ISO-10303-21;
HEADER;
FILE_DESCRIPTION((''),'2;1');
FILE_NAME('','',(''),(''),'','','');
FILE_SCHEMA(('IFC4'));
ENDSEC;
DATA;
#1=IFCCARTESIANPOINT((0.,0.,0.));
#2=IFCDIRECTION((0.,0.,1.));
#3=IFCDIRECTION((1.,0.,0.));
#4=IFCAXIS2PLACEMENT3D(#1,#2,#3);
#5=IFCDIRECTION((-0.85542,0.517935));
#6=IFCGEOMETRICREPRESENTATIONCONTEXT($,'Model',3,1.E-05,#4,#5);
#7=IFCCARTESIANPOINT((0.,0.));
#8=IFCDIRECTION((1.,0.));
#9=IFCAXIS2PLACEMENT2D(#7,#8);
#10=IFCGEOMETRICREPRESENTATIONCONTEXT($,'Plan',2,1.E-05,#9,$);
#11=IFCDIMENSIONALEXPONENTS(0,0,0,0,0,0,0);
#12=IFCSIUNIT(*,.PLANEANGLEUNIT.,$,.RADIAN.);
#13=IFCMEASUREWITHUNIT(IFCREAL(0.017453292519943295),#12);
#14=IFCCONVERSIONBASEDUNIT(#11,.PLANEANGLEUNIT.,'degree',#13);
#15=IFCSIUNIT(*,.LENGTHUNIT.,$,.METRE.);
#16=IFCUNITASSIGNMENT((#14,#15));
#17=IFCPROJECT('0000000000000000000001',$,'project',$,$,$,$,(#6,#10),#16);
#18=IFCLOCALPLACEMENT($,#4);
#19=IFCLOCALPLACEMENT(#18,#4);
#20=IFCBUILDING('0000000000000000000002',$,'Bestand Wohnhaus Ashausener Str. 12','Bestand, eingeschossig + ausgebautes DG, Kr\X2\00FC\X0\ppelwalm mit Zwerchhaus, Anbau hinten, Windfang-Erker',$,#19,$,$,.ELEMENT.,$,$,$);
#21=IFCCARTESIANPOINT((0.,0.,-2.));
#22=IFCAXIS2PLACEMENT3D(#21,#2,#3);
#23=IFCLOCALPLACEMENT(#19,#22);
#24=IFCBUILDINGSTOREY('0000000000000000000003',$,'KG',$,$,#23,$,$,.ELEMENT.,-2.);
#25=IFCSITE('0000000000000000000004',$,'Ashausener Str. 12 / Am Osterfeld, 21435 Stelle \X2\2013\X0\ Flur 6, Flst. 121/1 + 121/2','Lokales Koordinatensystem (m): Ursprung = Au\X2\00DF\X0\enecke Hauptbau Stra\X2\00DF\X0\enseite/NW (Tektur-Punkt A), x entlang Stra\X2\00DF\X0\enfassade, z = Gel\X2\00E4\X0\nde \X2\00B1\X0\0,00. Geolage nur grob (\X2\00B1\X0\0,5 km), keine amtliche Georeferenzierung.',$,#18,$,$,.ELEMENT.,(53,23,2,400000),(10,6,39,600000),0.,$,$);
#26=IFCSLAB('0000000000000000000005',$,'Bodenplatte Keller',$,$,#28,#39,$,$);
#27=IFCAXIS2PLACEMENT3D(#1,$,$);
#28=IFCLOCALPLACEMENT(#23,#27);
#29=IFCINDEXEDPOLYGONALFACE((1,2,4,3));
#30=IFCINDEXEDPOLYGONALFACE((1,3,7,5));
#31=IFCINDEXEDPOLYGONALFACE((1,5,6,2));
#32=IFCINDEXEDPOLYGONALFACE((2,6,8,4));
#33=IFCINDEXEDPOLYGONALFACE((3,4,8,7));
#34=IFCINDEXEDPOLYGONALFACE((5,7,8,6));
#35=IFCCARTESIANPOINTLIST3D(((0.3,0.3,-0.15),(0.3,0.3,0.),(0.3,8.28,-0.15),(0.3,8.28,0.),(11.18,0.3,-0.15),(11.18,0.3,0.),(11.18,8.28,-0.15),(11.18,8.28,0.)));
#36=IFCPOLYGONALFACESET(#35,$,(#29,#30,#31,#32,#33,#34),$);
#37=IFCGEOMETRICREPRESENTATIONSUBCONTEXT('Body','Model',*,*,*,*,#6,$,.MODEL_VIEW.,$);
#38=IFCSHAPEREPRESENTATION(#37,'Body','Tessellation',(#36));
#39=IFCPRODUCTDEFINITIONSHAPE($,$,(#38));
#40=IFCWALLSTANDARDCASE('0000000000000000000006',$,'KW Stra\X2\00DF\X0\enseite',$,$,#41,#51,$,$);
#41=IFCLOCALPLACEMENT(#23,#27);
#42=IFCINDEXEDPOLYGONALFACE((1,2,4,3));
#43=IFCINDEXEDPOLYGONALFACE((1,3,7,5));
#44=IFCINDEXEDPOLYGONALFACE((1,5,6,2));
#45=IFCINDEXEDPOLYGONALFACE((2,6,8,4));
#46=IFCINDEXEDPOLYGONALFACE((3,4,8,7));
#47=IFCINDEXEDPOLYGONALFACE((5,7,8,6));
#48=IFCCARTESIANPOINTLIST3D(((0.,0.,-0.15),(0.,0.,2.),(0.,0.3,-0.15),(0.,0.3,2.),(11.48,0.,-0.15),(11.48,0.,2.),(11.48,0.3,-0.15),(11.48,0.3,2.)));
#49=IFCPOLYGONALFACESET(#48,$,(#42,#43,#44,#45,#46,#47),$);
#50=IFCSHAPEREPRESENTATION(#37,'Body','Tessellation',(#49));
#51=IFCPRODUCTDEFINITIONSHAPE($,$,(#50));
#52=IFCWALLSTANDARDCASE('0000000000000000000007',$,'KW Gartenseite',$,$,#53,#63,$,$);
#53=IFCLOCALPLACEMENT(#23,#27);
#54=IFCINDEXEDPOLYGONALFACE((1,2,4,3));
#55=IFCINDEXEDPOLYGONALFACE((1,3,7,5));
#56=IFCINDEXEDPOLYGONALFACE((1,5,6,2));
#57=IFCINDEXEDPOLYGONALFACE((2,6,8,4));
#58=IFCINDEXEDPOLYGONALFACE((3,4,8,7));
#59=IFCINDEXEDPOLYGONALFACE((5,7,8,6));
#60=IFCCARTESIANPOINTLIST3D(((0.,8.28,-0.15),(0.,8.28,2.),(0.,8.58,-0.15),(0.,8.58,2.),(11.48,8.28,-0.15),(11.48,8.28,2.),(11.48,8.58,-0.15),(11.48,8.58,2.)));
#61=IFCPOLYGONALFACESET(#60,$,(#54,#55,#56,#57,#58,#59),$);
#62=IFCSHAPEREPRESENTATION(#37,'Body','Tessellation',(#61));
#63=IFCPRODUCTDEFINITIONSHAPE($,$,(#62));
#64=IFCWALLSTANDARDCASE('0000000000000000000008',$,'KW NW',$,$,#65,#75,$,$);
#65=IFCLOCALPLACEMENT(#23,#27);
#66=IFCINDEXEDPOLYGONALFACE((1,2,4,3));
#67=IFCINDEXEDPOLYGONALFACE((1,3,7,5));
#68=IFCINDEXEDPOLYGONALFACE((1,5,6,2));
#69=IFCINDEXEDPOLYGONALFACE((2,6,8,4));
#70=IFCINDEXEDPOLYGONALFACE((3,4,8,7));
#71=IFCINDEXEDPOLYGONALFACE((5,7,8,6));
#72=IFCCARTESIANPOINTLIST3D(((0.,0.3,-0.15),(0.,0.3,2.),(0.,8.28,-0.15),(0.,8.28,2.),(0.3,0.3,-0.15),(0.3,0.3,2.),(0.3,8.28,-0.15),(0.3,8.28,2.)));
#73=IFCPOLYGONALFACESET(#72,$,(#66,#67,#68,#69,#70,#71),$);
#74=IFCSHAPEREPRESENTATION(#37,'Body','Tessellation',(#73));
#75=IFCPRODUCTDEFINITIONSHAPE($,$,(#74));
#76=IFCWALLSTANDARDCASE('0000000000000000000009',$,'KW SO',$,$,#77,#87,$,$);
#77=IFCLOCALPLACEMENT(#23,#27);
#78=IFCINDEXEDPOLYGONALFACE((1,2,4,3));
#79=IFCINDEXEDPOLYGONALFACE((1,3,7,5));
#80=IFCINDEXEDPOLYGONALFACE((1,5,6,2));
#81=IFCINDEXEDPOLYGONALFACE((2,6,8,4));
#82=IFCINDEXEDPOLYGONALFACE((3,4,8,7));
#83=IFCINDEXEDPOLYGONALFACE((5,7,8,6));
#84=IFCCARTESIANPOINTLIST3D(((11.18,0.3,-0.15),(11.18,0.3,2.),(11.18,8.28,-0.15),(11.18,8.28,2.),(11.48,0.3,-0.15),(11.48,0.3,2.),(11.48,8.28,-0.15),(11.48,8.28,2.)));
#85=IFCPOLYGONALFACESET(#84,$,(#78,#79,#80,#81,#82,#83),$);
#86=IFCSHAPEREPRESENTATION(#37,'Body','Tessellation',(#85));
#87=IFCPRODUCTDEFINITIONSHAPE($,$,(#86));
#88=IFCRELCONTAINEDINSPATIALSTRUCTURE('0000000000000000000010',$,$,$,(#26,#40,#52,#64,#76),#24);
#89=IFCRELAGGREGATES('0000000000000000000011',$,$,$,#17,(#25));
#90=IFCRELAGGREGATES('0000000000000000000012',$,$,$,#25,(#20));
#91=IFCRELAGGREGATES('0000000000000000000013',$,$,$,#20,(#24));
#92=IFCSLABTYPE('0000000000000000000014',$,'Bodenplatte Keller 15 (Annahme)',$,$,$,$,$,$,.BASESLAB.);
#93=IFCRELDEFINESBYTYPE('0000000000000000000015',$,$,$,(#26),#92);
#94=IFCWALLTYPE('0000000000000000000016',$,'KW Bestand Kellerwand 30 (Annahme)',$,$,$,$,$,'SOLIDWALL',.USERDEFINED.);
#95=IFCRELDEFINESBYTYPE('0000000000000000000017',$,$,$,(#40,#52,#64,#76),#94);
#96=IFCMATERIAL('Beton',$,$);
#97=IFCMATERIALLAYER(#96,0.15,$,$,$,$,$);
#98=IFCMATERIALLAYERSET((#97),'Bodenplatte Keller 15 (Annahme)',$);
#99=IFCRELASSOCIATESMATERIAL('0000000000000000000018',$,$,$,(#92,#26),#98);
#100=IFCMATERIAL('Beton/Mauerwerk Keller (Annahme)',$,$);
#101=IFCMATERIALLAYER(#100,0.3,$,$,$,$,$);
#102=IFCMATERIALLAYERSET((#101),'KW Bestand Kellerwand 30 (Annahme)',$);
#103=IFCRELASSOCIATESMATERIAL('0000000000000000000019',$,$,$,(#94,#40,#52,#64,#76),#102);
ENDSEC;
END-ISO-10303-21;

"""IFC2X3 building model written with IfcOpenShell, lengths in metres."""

from ifc_helpers import new_model, entity, si_unit, converted_unit, direction, frame, origin_with_axes, origin_2d_with_axis, place, context, subcontext, project, spatial, polyline, outline, extrude, material, layer, layer_set, layer_usage, type_object, element, save


model = new_model("IFC2X3")

# Units and contexts
model_context = context("Model", 3, precision=1e-05, world=origin_with_axes(), true_north=direction((-0.85542, 0.517935)))
plan_context = context("Plan", 2, precision=1e-05, world=origin_2d_with_axis())
body_context = subcontext(model_context, "Body", "Model", "MODEL_VIEW")
ifc_project = project(units=[converted_unit("PLANEANGLEUNIT", "degree", entity("IfcReal", 0.017453292519943295), si_unit("PLANEANGLEUNIT", "RADIAN"), dimensions=[0, 0, 0, 0, 0, 0, 0]), si_unit("LENGTHUNIT", "METRE")], contexts=[model_context, plan_context])

# Site, building, storey
site_placement = place(None, origin_with_axes())
site = spatial("IfcSite", under=ifc_project, at=site_placement, Name="Ashausener Str. 12 / Am Osterfeld, 21435 Stelle – Flur 6, Flst. 121/1 + 121/2", Description="Lokales Koordinatensystem (m): Ursprung = Außenecke Hauptbau Straßenseite/NW (Tektur-Punkt A), x entlang Straßenfassade, z = Gelände ±0,00. Geolage nur grob (±0,5 km), keine amtliche Georeferenzierung.", CompositionType="ELEMENT", RefLatitude=(53, 23, 2, 400000), RefLongitude=(10, 6, 39, 600000), RefElevation=0.0)
building_placement = place(site_placement, origin_with_axes())
building = spatial("IfcBuilding", under=site, at=building_placement, Name="Bestand Wohnhaus Ashausener Str. 12", Description="Bestand, eingeschossig + ausgebautes DG, Krüppelwalm mit Zwerchhaus, Anbau hinten, Windfang-Erker", CompositionType="ELEMENT")
storey_placement = place(building_placement, frame((0.0, 0.0, -2.0), z_axis=(0.0, 0.0, 1.0), x_axis=(1.0, 0.0, 0.0)))
storey = spatial("IfcBuildingStorey", under=building, at=storey_placement, Name="KG", CompositionType="ELEMENT", Elevation=-2.0)

# Slab
ifc_material_1 = material(Name="Beton")
ifc_layer_1 = layer(ifc_material_1, 0.15)
ifc_layer_set_1 = layer_set([ifc_layer_1], Name="Bodenplatte Keller 15 (Annahme)")
ifc_layer_usage_1 = layer_usage(ifc_layer_set_1, "AXIS3", "POSITIVE", 0.0)
slab_type = type_object("IfcSlabType", Name="Bodenplatte Keller 15 (Annahme)", PredefinedType="BASESLAB", material=ifc_layer_set_1)
slab_placement = place(storey_placement, frame((0.0, 0.0, 2.0), z_axis=(0.0, 0.0, 1.0), x_axis=(1.0, 0.0, 0.0)))
element("IfcSlab", 1, at=slab_placement, inside=storey, type_object=slab_type, material=ifc_layer_usage_1, Name="Bodenplatte Keller", context=body_context, shape_type="SweptSolid", body=[
    extrude(outline(polyline([(0.3, 0.3), (11.18, 0.3), (11.18, 8.28), (0.3, 8.28), (0.3, 0.3)])), frame((0.0, 0.0, -2.15)), (0.0, 0.0, 1.0), 0.15),
])

# Walls
ifc_material_2 = material(Name="Beton/Mauerwerk Keller (Annahme)")
ifc_layer_2 = layer(ifc_material_2, 0.3)
ifc_layer_set_2 = layer_set([ifc_layer_2], Name="KW Bestand Kellerwand 30 (Annahme)")
ifc_layer_usage_2 = layer_usage(ifc_layer_set_2, "AXIS2", "POSITIVE", 0.0)
wall_type = type_object("IfcWallType", Name="KW Bestand Kellerwand 30 (Annahme)", ElementType="SOLIDWALL", PredefinedType="USERDEFINED", material=ifc_layer_set_2)
wall_1_placement = place(storey_placement, frame((0.0, 0.0, -0.15), z_axis=(0.0, 0.0, 1.0), x_axis=(1.0, 0.0, 0.0)))
element("IfcWallStandardCase", 2, at=wall_1_placement, inside=storey, type_object=wall_type, material=ifc_layer_usage_2, Name="KW Straßenseite", context=body_context, shape_type="SweptSolid", body=[
    extrude(outline(polyline([(0.0, 0.0), (0.0, 0.3), (11.48, 0.3), (11.48, 0.0), (0.0, 0.0)])), origin_with_axes(), (0.0, 0.0, 1.0), 2.15),
])
ifc_layer_usage_3 = layer_usage(ifc_layer_set_2, "AXIS2", "POSITIVE", 0.0)
wall_2_placement = place(storey_placement, frame((11.48, 8.58, -0.15), z_axis=(0.0, 0.0, 1.0), x_axis=(-1.0, 0.0, 0.0)))
element("IfcWallStandardCase", 3, at=wall_2_placement, inside=storey, type_object=wall_type, material=ifc_layer_usage_3, Name="KW Gartenseite", context=body_context, shape_type="SweptSolid", body=[
    extrude(outline(polyline([(0.0, 0.0), (0.0, 0.3), (11.48, 0.3), (11.48, 0.0), (0.0, 0.0)])), origin_with_axes(), (0.0, 0.0, 1.0), 2.15),
])
ifc_layer_usage_4 = layer_usage(ifc_layer_set_2, "AXIS2", "POSITIVE", 0.0)
wall_3_placement = place(storey_placement, frame((0.0, 8.28, -0.15), z_axis=(0.0, 0.0, 1.0), x_axis=(0.0, -1.0, 0.0)))
element("IfcWallStandardCase", 4, at=wall_3_placement, inside=storey, type_object=wall_type, material=ifc_layer_usage_4, Name="KW NW", context=body_context, shape_type="SweptSolid", body=[
    extrude(outline(polyline([(0.0, 0.0), (0.0, 0.3), (7.98, 0.3), (7.98, 0.0), (0.0, 0.0)])), origin_with_axes(), (0.0, 0.0, 1.0), 2.15),
])
ifc_layer_usage_5 = layer_usage(ifc_layer_set_2, "AXIS2", "POSITIVE", 0.0)
wall_4_placement = place(storey_placement, frame((11.48, 0.3, -0.15), z_axis=(0.0, 0.0, 1.0), x_axis=(0.0, 1.0, 0.0)))
element("IfcWallStandardCase", 5, at=wall_4_placement, inside=storey, type_object=wall_type, material=ifc_layer_usage_5, Name="KW SO", context=body_context, shape_type="SweptSolid", body=[
    extrude(outline(polyline([(0.0, 0.0), (0.0, 0.3), (7.98, 0.3), (7.98, 0.0), (0.0, 0.0)])), origin_with_axes(), (0.0, 0.0, 1.0), 2.15),
])

save(model, "model.ifc")
